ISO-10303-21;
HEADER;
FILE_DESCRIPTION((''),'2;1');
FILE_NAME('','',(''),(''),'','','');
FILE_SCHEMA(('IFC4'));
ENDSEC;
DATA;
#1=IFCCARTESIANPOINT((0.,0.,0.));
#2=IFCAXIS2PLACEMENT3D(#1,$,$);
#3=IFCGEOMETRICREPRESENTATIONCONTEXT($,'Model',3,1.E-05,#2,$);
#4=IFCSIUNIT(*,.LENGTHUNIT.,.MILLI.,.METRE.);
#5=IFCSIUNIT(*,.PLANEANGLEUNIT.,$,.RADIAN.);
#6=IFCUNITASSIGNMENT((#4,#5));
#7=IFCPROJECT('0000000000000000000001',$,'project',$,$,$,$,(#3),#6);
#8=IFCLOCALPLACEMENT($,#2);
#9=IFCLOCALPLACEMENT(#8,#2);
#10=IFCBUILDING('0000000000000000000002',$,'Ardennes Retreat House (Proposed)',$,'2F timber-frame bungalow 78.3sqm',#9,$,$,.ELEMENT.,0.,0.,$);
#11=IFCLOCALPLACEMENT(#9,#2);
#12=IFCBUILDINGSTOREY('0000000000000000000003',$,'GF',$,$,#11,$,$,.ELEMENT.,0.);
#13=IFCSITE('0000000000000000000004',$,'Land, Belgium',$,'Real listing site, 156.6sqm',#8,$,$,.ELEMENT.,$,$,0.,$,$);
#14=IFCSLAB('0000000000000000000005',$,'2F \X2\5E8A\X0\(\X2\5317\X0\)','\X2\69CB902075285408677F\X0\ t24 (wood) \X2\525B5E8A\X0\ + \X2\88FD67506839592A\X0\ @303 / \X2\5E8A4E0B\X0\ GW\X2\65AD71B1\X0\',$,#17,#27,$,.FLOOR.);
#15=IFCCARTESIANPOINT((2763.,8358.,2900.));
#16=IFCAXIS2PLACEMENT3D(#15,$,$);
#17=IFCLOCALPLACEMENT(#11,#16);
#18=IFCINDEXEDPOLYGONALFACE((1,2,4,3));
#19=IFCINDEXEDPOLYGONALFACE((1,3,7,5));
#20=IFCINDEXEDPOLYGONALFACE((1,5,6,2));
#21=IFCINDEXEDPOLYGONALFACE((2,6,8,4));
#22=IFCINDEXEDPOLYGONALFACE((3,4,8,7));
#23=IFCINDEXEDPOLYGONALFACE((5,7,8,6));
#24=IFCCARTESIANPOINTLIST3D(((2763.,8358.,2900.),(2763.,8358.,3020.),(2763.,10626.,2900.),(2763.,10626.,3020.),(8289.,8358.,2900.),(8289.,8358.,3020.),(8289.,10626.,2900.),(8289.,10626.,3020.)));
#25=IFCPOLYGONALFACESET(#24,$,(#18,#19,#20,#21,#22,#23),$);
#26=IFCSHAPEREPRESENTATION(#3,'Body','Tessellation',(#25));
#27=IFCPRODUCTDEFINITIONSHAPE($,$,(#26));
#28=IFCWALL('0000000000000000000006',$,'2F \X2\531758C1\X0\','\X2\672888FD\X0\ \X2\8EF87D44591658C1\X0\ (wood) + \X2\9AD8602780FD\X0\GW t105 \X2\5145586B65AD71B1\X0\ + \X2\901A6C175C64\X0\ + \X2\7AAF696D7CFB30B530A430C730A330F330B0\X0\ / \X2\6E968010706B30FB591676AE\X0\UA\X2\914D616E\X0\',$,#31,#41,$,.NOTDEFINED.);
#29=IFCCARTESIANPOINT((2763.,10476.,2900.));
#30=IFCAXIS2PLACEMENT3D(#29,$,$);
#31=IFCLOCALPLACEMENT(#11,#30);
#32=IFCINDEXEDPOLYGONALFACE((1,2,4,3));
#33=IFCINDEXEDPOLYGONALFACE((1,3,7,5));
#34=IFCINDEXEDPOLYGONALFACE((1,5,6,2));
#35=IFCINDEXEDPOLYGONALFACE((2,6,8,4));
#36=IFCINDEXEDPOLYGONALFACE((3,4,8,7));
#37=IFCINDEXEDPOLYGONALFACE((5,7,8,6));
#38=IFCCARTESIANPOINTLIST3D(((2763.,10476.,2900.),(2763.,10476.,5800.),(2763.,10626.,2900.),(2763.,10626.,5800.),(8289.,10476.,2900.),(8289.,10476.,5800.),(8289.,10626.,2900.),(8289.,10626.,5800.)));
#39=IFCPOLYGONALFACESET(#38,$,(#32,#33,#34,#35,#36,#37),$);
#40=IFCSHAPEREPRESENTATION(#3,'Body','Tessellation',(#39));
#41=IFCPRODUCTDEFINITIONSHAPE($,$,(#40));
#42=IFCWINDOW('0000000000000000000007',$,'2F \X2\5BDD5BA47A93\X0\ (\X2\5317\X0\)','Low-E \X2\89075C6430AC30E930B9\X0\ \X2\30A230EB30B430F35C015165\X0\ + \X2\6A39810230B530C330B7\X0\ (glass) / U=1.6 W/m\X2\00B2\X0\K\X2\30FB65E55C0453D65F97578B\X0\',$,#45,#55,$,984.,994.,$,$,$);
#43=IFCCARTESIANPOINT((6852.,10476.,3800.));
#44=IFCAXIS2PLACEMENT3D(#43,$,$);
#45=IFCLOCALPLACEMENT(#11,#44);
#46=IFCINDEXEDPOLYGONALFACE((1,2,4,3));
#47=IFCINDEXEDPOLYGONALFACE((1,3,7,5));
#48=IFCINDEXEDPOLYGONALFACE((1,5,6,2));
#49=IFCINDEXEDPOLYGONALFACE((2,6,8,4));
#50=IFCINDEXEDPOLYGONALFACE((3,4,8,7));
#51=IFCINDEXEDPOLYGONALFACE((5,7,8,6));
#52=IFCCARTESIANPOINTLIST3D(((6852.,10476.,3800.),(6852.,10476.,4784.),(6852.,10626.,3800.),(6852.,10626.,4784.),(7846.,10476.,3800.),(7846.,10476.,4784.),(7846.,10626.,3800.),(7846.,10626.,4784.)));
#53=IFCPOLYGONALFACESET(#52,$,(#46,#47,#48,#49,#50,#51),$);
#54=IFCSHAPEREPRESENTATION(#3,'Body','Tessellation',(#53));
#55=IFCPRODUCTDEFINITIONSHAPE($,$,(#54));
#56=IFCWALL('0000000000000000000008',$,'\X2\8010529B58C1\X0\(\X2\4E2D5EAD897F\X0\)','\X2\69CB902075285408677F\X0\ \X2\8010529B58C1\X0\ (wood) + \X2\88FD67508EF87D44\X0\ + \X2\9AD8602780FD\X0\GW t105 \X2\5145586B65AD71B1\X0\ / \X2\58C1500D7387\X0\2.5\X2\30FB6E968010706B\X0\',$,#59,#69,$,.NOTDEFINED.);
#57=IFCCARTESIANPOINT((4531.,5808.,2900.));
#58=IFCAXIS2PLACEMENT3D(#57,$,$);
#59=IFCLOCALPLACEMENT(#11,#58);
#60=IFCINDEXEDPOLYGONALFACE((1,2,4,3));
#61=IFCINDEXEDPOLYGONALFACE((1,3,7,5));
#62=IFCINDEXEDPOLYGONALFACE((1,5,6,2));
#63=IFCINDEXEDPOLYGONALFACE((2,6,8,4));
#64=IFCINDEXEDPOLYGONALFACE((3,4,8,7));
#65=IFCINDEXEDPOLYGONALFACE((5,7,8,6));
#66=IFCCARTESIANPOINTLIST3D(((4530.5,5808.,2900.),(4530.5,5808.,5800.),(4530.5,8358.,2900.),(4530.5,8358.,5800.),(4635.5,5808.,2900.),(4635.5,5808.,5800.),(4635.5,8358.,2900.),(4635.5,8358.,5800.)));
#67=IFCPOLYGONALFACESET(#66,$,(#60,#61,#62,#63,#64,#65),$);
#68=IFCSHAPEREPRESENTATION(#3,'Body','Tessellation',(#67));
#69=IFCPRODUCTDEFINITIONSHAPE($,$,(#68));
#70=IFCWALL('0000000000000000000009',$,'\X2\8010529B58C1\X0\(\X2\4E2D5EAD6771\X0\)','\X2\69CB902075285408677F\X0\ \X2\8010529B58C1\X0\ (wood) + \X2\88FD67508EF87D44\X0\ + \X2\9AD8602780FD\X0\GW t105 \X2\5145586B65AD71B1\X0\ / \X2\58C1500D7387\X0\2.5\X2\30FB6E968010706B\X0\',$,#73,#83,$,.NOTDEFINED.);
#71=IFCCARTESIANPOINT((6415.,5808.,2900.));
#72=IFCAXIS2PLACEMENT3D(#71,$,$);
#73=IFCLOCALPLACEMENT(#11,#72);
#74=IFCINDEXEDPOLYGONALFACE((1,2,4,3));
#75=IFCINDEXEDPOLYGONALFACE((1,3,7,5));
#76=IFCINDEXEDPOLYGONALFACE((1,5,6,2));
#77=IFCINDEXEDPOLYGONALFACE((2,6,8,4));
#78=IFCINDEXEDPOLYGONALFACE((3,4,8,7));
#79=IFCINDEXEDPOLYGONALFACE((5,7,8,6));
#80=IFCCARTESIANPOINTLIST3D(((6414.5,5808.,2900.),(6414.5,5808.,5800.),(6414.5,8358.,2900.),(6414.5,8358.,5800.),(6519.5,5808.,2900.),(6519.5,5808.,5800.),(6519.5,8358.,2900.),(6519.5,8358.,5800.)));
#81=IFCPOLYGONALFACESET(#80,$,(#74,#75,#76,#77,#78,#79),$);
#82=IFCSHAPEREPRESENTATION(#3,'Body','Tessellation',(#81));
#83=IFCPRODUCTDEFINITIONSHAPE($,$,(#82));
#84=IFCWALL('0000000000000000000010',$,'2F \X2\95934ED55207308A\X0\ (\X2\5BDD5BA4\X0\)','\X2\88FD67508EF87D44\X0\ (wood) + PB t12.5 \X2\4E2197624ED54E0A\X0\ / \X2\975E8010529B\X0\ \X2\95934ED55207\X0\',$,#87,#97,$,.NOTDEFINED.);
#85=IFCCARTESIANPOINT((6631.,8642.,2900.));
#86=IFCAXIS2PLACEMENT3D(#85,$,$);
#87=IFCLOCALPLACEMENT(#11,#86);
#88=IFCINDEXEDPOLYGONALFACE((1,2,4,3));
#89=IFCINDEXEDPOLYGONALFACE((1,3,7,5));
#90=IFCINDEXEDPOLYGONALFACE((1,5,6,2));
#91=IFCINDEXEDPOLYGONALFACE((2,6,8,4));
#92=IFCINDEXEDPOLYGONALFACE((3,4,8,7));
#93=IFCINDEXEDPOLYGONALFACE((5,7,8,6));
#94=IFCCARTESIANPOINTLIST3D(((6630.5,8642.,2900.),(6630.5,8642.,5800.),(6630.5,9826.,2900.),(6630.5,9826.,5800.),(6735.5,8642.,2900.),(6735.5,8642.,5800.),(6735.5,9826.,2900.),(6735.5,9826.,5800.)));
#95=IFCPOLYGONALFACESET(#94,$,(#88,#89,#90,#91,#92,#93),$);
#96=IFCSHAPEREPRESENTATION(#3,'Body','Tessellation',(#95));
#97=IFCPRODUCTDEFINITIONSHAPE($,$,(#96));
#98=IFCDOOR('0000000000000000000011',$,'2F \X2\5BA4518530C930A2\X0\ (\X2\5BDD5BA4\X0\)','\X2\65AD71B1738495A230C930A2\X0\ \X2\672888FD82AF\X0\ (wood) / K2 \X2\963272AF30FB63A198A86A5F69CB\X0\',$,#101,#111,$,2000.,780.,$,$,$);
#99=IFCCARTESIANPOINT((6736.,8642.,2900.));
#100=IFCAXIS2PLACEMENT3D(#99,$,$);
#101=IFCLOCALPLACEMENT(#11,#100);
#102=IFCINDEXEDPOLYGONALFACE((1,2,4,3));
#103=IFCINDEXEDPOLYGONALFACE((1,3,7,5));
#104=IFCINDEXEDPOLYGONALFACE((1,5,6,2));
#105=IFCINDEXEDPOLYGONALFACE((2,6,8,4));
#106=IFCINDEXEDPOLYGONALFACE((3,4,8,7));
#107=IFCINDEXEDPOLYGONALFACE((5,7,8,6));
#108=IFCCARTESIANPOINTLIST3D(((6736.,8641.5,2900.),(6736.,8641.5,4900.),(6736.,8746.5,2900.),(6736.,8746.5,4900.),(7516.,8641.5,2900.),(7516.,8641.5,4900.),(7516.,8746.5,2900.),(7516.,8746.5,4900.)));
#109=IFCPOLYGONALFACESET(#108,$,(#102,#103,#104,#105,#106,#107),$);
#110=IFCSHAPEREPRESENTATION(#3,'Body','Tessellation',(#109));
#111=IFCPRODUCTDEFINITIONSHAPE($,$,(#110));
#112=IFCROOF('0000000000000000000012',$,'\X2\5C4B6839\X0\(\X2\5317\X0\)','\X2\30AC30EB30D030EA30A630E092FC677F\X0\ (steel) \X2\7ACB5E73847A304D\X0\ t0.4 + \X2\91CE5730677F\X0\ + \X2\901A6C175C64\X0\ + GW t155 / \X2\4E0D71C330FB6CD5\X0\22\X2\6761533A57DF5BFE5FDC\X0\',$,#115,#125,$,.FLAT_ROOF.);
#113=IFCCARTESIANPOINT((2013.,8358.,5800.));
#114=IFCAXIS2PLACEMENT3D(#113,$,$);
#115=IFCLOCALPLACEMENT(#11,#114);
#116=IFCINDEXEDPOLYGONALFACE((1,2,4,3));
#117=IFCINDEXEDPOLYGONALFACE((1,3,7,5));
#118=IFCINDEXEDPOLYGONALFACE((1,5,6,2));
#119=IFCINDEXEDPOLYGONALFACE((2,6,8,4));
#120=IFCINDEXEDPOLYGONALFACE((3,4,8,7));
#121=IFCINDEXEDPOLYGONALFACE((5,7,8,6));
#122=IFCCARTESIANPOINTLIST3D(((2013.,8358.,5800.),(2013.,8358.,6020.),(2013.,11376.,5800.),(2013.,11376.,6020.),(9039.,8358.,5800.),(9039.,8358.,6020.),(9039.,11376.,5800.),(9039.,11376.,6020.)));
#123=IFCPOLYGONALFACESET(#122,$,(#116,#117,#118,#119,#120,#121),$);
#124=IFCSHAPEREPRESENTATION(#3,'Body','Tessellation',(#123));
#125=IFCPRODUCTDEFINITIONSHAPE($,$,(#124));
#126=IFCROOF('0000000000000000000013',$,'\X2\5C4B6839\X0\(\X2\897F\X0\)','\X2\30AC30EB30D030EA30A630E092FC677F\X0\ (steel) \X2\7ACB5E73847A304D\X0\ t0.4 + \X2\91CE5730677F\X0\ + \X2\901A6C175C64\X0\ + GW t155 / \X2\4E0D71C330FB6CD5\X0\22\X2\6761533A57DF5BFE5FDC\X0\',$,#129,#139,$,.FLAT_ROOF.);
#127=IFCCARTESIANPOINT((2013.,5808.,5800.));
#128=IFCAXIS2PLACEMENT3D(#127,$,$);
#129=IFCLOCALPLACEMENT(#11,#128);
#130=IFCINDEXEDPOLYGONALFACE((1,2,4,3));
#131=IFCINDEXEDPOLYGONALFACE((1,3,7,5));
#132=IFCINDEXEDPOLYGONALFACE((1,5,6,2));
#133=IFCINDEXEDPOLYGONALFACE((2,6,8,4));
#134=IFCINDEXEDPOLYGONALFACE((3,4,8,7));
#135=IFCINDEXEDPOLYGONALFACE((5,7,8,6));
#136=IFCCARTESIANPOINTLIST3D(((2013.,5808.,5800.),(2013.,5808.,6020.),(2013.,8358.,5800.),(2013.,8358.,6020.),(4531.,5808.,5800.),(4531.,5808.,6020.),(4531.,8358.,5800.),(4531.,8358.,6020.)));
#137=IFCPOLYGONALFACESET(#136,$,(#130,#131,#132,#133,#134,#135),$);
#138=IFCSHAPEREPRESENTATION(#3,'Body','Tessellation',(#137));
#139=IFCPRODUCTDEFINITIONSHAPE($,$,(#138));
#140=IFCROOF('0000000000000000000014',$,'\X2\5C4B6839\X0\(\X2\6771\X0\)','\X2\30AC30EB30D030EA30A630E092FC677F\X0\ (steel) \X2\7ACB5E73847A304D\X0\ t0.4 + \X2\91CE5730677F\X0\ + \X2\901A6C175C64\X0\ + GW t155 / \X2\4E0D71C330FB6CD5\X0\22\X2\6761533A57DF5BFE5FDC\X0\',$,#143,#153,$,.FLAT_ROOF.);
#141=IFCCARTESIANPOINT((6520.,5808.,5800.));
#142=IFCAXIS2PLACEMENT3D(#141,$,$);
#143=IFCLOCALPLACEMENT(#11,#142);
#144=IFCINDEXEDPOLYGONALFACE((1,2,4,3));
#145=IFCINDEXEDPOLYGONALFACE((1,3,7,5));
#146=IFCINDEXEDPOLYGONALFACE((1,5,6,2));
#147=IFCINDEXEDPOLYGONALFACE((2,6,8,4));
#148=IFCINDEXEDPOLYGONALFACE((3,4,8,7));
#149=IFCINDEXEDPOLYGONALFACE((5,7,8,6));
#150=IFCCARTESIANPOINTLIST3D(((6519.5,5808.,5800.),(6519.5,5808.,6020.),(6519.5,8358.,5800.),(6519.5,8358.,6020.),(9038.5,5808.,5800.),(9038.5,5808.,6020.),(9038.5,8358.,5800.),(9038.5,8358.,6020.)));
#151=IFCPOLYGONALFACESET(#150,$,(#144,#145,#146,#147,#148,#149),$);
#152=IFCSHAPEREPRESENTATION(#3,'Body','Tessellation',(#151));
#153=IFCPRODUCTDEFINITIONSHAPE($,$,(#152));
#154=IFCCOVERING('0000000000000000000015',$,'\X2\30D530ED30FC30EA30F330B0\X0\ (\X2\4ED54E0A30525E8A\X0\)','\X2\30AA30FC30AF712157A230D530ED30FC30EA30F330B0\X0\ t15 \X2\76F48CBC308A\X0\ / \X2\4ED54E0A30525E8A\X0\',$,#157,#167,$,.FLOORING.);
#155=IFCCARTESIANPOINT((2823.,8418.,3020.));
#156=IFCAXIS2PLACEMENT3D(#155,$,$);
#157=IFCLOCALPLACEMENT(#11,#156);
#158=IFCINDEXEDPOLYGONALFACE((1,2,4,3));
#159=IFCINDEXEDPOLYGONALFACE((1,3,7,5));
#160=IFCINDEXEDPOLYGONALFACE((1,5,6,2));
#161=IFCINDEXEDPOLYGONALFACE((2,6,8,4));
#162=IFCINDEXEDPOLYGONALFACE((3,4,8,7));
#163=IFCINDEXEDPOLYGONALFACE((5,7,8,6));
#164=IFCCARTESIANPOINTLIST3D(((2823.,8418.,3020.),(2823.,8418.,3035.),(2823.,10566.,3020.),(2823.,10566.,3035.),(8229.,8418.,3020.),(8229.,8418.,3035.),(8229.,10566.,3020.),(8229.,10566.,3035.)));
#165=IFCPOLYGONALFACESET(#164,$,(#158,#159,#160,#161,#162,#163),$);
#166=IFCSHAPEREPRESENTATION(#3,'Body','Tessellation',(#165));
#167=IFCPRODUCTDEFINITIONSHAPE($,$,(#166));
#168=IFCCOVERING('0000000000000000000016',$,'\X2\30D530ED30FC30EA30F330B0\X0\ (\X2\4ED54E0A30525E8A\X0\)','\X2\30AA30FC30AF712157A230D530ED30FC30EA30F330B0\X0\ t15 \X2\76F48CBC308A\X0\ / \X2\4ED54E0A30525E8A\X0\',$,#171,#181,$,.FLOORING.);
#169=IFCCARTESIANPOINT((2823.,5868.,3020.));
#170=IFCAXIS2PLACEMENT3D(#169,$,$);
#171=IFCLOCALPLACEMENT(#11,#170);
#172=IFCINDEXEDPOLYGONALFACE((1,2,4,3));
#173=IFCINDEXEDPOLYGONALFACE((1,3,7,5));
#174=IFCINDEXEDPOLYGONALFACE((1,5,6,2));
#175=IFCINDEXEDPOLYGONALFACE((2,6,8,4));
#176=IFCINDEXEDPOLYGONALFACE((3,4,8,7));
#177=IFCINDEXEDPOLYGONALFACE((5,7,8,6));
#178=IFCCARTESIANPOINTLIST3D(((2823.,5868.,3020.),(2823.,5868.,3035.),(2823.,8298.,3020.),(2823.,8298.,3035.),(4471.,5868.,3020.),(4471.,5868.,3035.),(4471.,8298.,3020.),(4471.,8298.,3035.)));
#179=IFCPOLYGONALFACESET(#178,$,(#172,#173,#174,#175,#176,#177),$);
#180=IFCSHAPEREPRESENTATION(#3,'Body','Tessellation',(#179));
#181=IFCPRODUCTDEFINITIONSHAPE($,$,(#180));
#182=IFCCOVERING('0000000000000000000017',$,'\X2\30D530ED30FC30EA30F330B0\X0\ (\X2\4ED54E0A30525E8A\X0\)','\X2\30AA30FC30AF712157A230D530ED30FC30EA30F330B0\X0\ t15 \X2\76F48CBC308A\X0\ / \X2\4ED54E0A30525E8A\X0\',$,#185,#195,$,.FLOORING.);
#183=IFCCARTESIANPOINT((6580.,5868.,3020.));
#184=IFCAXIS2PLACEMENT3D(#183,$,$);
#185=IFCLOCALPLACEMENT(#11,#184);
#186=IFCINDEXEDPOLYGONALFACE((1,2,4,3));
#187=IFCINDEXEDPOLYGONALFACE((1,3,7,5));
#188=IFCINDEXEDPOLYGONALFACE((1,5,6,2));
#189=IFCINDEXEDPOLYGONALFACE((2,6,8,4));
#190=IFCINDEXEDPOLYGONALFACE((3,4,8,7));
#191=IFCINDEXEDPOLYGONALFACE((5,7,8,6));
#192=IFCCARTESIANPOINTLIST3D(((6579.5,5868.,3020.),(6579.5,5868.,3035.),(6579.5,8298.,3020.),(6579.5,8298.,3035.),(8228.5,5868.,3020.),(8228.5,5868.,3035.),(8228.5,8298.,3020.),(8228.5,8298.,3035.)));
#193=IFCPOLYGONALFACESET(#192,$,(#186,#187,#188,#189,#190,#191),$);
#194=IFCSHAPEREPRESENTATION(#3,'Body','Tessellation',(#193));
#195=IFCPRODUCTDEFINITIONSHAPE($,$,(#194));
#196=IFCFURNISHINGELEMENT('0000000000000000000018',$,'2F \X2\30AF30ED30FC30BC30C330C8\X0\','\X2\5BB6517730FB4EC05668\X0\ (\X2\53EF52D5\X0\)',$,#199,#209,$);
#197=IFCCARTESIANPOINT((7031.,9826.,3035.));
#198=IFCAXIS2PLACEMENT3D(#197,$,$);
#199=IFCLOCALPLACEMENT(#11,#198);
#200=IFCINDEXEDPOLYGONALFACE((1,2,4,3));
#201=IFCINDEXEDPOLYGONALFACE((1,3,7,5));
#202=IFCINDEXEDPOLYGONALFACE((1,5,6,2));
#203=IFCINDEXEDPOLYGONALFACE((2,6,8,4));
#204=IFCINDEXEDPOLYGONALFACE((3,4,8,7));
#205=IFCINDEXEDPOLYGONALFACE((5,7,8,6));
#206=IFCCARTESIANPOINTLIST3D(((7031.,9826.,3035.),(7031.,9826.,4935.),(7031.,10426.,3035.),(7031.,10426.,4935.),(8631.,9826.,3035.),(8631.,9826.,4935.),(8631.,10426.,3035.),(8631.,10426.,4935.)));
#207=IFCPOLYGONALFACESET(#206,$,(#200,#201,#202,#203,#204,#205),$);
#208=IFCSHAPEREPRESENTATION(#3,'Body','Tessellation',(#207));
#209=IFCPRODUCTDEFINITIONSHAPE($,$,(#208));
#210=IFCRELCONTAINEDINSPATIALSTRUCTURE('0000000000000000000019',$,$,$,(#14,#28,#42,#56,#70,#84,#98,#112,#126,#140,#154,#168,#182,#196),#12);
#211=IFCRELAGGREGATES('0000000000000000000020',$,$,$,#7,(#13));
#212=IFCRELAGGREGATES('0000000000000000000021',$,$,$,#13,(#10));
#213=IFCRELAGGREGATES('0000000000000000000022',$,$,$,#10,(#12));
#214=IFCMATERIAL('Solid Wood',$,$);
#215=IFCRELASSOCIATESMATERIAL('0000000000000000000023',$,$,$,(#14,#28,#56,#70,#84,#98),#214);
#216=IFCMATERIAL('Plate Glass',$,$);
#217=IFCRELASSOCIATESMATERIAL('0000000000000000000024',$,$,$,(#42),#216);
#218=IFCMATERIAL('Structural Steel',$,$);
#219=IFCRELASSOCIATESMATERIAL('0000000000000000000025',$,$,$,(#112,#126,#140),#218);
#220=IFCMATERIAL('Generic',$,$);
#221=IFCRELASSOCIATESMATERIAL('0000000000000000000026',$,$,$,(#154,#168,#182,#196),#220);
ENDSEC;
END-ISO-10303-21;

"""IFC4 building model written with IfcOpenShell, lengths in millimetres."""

from ifc_helpers import new_model, si_unit, frame, frame_2d, origin, place, context, project, spatial, rectangle, extrude, material, element, fill, save


model = new_model("IFC4")

# Units and contexts
model_context = context("Model", 3, precision=1e-05, world=origin())
ifc_project = project(units=[si_unit("LENGTHUNIT", "METRE", prefix="MILLI"), si_unit("PLANEANGLEUNIT", "RADIAN")], contexts=[model_context])

# Site, building, storey
site_placement = place(None, origin())
site = spatial("IfcSite", under=ifc_project, at=site_placement, Name="Land, Belgium", ObjectType="Real listing site, 156.6sqm", CompositionType="ELEMENT", RefElevation=0.0)
building_placement = place(site_placement, origin())
building = spatial("IfcBuilding", under=site, at=building_placement, Name="Ardennes Retreat House (Proposed)", ObjectType="2F timber-frame bungalow 78.3sqm", CompositionType="ELEMENT", ElevationOfRefHeight=0.0, ElevationOfTerrain=0.0)
storey_placement = place(building_placement, origin())
storey = spatial("IfcBuildingStorey", under=building, at=storey_placement, Name="GF", CompositionType="ELEMENT", Elevation=0.0)

# Slab
ifc_material_1 = material(Name="Solid Wood")
slab_placement = place(storey_placement, frame((2763.0, 8358.0, 2900.0)))
element("IfcSlab", 1, at=slab_placement, inside=storey, material=ifc_material_1, Name="2F 床(北)", Description="構造用合板 t24 (wood) 剛床 + 製材根太 @303 / 床下 GW断熱", PredefinedType="FLOOR", context=model_context, shape_type="SweptSolid", body=[
    extrude(rectangle(XDim=5526.0, YDim=2268.0, at=frame_2d((2763.0, 1134.0))), frame((2763.0, 8358.0, 2900.0)), (0.0, 0.0, 1.0), 120.0),
])

# Wall, opening, window
wall_1_placement = place(storey_placement, frame((2763.0, 10476.0, 2900.0)))
wall_1 = element("IfcWall", 2, at=wall_1_placement, inside=storey, material=ifc_material_1, Name="2F 北壁", Description="木製 軸組外壁 (wood) + 高性能GW t105 充填断熱 + 通気層 + 窯業系サイディング / 準耐火・外皮UA配慮", PredefinedType="NOTDEFINED", context=model_context, shape_type="SweptSolid", body=[
    extrude(rectangle(XDim=5526.0, YDim=150.0, at=frame_2d((2763.0, 75.0))), frame((2763.0, 10476.0, 2900.0)), (0.0, 0.0, 1.0), 2900.0),
])
opening_1_placement = place(storey_placement, frame((6852.0, 10476.0, 3800.0)))
opening_1 = element("IfcOpeningElement", 3, at=opening_1_placement, cuts=wall_1, PredefinedType="NOTDEFINED", context=model_context, shape_type="SweptSolid", body=[
    extrude(rectangle(XDim=994.0, YDim=150.0, at=frame_2d((497.0, 75.0))), frame((6852.0, 10476.0, 3800.0)), (0.0, 0.0, 1.0), 984.0),
])
ifc_material_2 = material(Name="Plate Glass")
window_1_placement = place(storey_placement, frame((6852.0, 10476.0, 3800.0)))
window_1 = element("IfcWindow", 4, at=window_1_placement, inside=storey, material=ifc_material_2, Name="2F 寝室窓 (北)", Description="Low-E 複層ガラス アルゴン封入 + 樹脂サッシ (glass) / U=1.6 W/m²K・日射取得型", OverallHeight=984.0, OverallWidth=994.0, context=model_context, shape_type="SweptSolid", body=[
    extrude(rectangle(XDim=994.0, YDim=150.0, at=frame_2d((497.0, 75.0))), frame((6852.0, 10476.0, 3800.0)), (0.0, 0.0, 1.0), 984.0),
])
fill(opening_1, window_1)

# Walls
wall_2_placement = place(storey_placement, frame((4531.0, 5808.0, 2900.0)))
element("IfcWall", 5, at=wall_2_placement, inside=storey, material=ifc_material_1, Name="耐力壁(中庭西)", Description="構造用合板 耐力壁 (wood) + 製材軸組 + 高性能GW t105 充填断熱 / 壁倍率2.5・準耐火", PredefinedType="NOTDEFINED", context=model_context, shape_type="SweptSolid", body=[
    extrude(rectangle(XDim=105.0, YDim=2550.0, at=frame_2d((52.0, 1275.0))), frame((4531.0, 5808.0, 2900.0)), (0.0, 0.0, 1.0), 2900.0),
])
wall_3_placement = place(storey_placement, frame((6415.0, 5808.0, 2900.0)))
element("IfcWall", 6, at=wall_3_placement, inside=storey, material=ifc_material_1, Name="耐力壁(中庭東)", Description="構造用合板 耐力壁 (wood) + 製材軸組 + 高性能GW t105 充填断熱 / 壁倍率2.5・準耐火", PredefinedType="NOTDEFINED", context=model_context, shape_type="SweptSolid", body=[
    extrude(rectangle(XDim=105.0, YDim=2550.0, at=frame_2d((52.0, 1275.0))), frame((6415.0, 5808.0, 2900.0)), (0.0, 0.0, 1.0), 2900.0),
])
wall_4_placement = place(storey_placement, frame((6631.0, 8642.0, 2900.0)))
element("IfcWall", 7, at=wall_4_placement, inside=storey, material=ifc_material_1, Name="2F 間仕切り (寝室)", Description="製材軸組 (wood) + PB t12.5 両面仕上 / 非耐力 間仕切", PredefinedType="NOTDEFINED", context=model_context, shape_type="SweptSolid", body=[
    extrude(rectangle(XDim=105.0, YDim=1184.0, at=frame_2d((52.0, 592.0))), frame((6631.0, 8642.0, 2900.0)), (0.0, 0.0, 1.0), 2900.0),
])

# Door
door_placement = place(storey_placement, frame((6736.0, 8642.0, 2900.0)))
element("IfcDoor", 8, at=door_placement, inside=storey, material=ifc_material_1, Name="2F 室内ドア (寝室)", Description="断熱玄関ドア 木製芯 (wood) / K2 防犯・採風機構", OverallHeight=2000.0, OverallWidth=780.0, context=model_context, shape_type="SweptSolid", body=[
    extrude(rectangle(XDim=780.0, YDim=105.0, at=frame_2d((390.0, 52.0))), frame((6736.0, 8642.0, 2900.0)), (0.0, 0.0, 1.0), 2000.0),
])

# Roofs
ifc_material_3 = material(Name="Structural Steel")
for number, where, name in (
    (9, (2013.0, 8358.0, 5800.0), "屋根(北)"),
):
    element("IfcRoof", number, at=place(storey_placement, frame(where)), inside=storey, material=ifc_material_3, Name=name, Description="ガルバリウム鋼板 (steel) 立平葺き t0.4 + 野地板 + 通気層 + GW t155 / 不燃・法22条区域対応", PredefinedType="FLAT_ROOF", context=model_context, shape_type="SweptSolid", body=[
        extrude(rectangle(XDim=7026.0, YDim=3018.0, at=frame_2d((3513.0, 1509.0))), frame((2013.0, 8358.0, 5800.0)), (0.0, 0.0, 1.0), 220.0),
    ])
roof_1_placement = place(storey_placement, frame((2013.0, 5808.0, 5800.0)))
element("IfcRoof", 10, at=roof_1_placement, inside=storey, material=ifc_material_3, Name="屋根(西)", Description="ガルバリウム鋼板 (steel) 立平葺き t0.4 + 野地板 + 通気層 + GW t155 / 不燃・法22条区域対応", PredefinedType="FLAT_ROOF", context=model_context, shape_type="SweptSolid", body=[
    extrude(rectangle(XDim=2518.0, YDim=2550.0, at=frame_2d((1259.0, 1275.0))), frame((2013.0, 5808.0, 5800.0)), (0.0, 0.0, 1.0), 220.0),
])
roof_2_placement = place(storey_placement, frame((6520.0, 5808.0, 5800.0)))
element("IfcRoof", 11, at=roof_2_placement, inside=storey, material=ifc_material_3, Name="屋根(東)", Description="ガルバリウム鋼板 (steel) 立平葺き t0.4 + 野地板 + 通気層 + GW t155 / 不燃・法22条区域対応", PredefinedType="FLAT_ROOF", context=model_context, shape_type="SweptSolid", body=[
    extrude(rectangle(XDim=2519.0, YDim=2550.0, at=frame_2d((1259.0, 1275.0))), frame((6520.0, 5808.0, 5800.0)), (0.0, 0.0, 1.0), 220.0),
])

# Coverings
ifc_material_4 = material(Name="Generic")
covering_1_placement = place(storey_placement, frame((2823.0, 8418.0, 3020.0)))
element("IfcCovering", 12, at=covering_1_placement, inside=storey, material=ifc_material_4, Name="フローリング (仕上げ床)", Description="オーク無垢フローリング t15 直貼り / 仕上げ床", PredefinedType="FLOORING", context=model_context, shape_type="SweptSolid", body=[
    extrude(rectangle(XDim=5406.0, YDim=2148.0, at=frame_2d((2703.0, 1074.0))), frame((2823.0, 8418.0, 3020.0)), (0.0, 0.0, 1.0), 15.0),
])
covering_2_placement = place(storey_placement, frame((2823.0, 5868.0, 3020.0)))
element("IfcCovering", 13, at=covering_2_placement, inside=storey, material=ifc_material_4, Name="フローリング (仕上げ床)", Description="オーク無垢フローリング t15 直貼り / 仕上げ床", PredefinedType="FLOORING", context=model_context, shape_type="SweptSolid", body=[
    extrude(rectangle(XDim=1648.0, YDim=2430.0, at=frame_2d((824.0, 1215.0))), frame((2823.0, 5868.0, 3020.0)), (0.0, 0.0, 1.0), 15.0),
])
covering_3_placement = place(storey_placement, frame((6580.0, 5868.0, 3020.0)))
element("IfcCovering", 14, at=covering_3_placement, inside=storey, material=ifc_material_4, Name="フローリング (仕上げ床)", Description="オーク無垢フローリング t15 直貼り / 仕上げ床", PredefinedType="FLOORING", context=model_context, shape_type="SweptSolid", body=[
    extrude(rectangle(XDim=1649.0, YDim=2430.0, at=frame_2d((824.0, 1215.0))), frame((6580.0, 5868.0, 3020.0)), (0.0, 0.0, 1.0), 15.0),
])

# Furnishing element
furnishing_1_placement = place(storey_placement, frame((7031.0, 9826.0, 3035.0)))
element("IfcFurnishingElement", 15, at=furnishing_1_placement, inside=storey, material=ifc_material_4, Name="2F クローゼット", Description="家具・什器 (可動)", context=model_context, shape_type="SweptSolid", body=[
    extrude(rectangle(XDim=1600.0, YDim=600.0, at=frame_2d((800.0, 300.0))), frame((7031.0, 9826.0, 3035.0)), (0.0, 0.0, 1.0), 1900.0),
])

save(model, "model.ifc")
